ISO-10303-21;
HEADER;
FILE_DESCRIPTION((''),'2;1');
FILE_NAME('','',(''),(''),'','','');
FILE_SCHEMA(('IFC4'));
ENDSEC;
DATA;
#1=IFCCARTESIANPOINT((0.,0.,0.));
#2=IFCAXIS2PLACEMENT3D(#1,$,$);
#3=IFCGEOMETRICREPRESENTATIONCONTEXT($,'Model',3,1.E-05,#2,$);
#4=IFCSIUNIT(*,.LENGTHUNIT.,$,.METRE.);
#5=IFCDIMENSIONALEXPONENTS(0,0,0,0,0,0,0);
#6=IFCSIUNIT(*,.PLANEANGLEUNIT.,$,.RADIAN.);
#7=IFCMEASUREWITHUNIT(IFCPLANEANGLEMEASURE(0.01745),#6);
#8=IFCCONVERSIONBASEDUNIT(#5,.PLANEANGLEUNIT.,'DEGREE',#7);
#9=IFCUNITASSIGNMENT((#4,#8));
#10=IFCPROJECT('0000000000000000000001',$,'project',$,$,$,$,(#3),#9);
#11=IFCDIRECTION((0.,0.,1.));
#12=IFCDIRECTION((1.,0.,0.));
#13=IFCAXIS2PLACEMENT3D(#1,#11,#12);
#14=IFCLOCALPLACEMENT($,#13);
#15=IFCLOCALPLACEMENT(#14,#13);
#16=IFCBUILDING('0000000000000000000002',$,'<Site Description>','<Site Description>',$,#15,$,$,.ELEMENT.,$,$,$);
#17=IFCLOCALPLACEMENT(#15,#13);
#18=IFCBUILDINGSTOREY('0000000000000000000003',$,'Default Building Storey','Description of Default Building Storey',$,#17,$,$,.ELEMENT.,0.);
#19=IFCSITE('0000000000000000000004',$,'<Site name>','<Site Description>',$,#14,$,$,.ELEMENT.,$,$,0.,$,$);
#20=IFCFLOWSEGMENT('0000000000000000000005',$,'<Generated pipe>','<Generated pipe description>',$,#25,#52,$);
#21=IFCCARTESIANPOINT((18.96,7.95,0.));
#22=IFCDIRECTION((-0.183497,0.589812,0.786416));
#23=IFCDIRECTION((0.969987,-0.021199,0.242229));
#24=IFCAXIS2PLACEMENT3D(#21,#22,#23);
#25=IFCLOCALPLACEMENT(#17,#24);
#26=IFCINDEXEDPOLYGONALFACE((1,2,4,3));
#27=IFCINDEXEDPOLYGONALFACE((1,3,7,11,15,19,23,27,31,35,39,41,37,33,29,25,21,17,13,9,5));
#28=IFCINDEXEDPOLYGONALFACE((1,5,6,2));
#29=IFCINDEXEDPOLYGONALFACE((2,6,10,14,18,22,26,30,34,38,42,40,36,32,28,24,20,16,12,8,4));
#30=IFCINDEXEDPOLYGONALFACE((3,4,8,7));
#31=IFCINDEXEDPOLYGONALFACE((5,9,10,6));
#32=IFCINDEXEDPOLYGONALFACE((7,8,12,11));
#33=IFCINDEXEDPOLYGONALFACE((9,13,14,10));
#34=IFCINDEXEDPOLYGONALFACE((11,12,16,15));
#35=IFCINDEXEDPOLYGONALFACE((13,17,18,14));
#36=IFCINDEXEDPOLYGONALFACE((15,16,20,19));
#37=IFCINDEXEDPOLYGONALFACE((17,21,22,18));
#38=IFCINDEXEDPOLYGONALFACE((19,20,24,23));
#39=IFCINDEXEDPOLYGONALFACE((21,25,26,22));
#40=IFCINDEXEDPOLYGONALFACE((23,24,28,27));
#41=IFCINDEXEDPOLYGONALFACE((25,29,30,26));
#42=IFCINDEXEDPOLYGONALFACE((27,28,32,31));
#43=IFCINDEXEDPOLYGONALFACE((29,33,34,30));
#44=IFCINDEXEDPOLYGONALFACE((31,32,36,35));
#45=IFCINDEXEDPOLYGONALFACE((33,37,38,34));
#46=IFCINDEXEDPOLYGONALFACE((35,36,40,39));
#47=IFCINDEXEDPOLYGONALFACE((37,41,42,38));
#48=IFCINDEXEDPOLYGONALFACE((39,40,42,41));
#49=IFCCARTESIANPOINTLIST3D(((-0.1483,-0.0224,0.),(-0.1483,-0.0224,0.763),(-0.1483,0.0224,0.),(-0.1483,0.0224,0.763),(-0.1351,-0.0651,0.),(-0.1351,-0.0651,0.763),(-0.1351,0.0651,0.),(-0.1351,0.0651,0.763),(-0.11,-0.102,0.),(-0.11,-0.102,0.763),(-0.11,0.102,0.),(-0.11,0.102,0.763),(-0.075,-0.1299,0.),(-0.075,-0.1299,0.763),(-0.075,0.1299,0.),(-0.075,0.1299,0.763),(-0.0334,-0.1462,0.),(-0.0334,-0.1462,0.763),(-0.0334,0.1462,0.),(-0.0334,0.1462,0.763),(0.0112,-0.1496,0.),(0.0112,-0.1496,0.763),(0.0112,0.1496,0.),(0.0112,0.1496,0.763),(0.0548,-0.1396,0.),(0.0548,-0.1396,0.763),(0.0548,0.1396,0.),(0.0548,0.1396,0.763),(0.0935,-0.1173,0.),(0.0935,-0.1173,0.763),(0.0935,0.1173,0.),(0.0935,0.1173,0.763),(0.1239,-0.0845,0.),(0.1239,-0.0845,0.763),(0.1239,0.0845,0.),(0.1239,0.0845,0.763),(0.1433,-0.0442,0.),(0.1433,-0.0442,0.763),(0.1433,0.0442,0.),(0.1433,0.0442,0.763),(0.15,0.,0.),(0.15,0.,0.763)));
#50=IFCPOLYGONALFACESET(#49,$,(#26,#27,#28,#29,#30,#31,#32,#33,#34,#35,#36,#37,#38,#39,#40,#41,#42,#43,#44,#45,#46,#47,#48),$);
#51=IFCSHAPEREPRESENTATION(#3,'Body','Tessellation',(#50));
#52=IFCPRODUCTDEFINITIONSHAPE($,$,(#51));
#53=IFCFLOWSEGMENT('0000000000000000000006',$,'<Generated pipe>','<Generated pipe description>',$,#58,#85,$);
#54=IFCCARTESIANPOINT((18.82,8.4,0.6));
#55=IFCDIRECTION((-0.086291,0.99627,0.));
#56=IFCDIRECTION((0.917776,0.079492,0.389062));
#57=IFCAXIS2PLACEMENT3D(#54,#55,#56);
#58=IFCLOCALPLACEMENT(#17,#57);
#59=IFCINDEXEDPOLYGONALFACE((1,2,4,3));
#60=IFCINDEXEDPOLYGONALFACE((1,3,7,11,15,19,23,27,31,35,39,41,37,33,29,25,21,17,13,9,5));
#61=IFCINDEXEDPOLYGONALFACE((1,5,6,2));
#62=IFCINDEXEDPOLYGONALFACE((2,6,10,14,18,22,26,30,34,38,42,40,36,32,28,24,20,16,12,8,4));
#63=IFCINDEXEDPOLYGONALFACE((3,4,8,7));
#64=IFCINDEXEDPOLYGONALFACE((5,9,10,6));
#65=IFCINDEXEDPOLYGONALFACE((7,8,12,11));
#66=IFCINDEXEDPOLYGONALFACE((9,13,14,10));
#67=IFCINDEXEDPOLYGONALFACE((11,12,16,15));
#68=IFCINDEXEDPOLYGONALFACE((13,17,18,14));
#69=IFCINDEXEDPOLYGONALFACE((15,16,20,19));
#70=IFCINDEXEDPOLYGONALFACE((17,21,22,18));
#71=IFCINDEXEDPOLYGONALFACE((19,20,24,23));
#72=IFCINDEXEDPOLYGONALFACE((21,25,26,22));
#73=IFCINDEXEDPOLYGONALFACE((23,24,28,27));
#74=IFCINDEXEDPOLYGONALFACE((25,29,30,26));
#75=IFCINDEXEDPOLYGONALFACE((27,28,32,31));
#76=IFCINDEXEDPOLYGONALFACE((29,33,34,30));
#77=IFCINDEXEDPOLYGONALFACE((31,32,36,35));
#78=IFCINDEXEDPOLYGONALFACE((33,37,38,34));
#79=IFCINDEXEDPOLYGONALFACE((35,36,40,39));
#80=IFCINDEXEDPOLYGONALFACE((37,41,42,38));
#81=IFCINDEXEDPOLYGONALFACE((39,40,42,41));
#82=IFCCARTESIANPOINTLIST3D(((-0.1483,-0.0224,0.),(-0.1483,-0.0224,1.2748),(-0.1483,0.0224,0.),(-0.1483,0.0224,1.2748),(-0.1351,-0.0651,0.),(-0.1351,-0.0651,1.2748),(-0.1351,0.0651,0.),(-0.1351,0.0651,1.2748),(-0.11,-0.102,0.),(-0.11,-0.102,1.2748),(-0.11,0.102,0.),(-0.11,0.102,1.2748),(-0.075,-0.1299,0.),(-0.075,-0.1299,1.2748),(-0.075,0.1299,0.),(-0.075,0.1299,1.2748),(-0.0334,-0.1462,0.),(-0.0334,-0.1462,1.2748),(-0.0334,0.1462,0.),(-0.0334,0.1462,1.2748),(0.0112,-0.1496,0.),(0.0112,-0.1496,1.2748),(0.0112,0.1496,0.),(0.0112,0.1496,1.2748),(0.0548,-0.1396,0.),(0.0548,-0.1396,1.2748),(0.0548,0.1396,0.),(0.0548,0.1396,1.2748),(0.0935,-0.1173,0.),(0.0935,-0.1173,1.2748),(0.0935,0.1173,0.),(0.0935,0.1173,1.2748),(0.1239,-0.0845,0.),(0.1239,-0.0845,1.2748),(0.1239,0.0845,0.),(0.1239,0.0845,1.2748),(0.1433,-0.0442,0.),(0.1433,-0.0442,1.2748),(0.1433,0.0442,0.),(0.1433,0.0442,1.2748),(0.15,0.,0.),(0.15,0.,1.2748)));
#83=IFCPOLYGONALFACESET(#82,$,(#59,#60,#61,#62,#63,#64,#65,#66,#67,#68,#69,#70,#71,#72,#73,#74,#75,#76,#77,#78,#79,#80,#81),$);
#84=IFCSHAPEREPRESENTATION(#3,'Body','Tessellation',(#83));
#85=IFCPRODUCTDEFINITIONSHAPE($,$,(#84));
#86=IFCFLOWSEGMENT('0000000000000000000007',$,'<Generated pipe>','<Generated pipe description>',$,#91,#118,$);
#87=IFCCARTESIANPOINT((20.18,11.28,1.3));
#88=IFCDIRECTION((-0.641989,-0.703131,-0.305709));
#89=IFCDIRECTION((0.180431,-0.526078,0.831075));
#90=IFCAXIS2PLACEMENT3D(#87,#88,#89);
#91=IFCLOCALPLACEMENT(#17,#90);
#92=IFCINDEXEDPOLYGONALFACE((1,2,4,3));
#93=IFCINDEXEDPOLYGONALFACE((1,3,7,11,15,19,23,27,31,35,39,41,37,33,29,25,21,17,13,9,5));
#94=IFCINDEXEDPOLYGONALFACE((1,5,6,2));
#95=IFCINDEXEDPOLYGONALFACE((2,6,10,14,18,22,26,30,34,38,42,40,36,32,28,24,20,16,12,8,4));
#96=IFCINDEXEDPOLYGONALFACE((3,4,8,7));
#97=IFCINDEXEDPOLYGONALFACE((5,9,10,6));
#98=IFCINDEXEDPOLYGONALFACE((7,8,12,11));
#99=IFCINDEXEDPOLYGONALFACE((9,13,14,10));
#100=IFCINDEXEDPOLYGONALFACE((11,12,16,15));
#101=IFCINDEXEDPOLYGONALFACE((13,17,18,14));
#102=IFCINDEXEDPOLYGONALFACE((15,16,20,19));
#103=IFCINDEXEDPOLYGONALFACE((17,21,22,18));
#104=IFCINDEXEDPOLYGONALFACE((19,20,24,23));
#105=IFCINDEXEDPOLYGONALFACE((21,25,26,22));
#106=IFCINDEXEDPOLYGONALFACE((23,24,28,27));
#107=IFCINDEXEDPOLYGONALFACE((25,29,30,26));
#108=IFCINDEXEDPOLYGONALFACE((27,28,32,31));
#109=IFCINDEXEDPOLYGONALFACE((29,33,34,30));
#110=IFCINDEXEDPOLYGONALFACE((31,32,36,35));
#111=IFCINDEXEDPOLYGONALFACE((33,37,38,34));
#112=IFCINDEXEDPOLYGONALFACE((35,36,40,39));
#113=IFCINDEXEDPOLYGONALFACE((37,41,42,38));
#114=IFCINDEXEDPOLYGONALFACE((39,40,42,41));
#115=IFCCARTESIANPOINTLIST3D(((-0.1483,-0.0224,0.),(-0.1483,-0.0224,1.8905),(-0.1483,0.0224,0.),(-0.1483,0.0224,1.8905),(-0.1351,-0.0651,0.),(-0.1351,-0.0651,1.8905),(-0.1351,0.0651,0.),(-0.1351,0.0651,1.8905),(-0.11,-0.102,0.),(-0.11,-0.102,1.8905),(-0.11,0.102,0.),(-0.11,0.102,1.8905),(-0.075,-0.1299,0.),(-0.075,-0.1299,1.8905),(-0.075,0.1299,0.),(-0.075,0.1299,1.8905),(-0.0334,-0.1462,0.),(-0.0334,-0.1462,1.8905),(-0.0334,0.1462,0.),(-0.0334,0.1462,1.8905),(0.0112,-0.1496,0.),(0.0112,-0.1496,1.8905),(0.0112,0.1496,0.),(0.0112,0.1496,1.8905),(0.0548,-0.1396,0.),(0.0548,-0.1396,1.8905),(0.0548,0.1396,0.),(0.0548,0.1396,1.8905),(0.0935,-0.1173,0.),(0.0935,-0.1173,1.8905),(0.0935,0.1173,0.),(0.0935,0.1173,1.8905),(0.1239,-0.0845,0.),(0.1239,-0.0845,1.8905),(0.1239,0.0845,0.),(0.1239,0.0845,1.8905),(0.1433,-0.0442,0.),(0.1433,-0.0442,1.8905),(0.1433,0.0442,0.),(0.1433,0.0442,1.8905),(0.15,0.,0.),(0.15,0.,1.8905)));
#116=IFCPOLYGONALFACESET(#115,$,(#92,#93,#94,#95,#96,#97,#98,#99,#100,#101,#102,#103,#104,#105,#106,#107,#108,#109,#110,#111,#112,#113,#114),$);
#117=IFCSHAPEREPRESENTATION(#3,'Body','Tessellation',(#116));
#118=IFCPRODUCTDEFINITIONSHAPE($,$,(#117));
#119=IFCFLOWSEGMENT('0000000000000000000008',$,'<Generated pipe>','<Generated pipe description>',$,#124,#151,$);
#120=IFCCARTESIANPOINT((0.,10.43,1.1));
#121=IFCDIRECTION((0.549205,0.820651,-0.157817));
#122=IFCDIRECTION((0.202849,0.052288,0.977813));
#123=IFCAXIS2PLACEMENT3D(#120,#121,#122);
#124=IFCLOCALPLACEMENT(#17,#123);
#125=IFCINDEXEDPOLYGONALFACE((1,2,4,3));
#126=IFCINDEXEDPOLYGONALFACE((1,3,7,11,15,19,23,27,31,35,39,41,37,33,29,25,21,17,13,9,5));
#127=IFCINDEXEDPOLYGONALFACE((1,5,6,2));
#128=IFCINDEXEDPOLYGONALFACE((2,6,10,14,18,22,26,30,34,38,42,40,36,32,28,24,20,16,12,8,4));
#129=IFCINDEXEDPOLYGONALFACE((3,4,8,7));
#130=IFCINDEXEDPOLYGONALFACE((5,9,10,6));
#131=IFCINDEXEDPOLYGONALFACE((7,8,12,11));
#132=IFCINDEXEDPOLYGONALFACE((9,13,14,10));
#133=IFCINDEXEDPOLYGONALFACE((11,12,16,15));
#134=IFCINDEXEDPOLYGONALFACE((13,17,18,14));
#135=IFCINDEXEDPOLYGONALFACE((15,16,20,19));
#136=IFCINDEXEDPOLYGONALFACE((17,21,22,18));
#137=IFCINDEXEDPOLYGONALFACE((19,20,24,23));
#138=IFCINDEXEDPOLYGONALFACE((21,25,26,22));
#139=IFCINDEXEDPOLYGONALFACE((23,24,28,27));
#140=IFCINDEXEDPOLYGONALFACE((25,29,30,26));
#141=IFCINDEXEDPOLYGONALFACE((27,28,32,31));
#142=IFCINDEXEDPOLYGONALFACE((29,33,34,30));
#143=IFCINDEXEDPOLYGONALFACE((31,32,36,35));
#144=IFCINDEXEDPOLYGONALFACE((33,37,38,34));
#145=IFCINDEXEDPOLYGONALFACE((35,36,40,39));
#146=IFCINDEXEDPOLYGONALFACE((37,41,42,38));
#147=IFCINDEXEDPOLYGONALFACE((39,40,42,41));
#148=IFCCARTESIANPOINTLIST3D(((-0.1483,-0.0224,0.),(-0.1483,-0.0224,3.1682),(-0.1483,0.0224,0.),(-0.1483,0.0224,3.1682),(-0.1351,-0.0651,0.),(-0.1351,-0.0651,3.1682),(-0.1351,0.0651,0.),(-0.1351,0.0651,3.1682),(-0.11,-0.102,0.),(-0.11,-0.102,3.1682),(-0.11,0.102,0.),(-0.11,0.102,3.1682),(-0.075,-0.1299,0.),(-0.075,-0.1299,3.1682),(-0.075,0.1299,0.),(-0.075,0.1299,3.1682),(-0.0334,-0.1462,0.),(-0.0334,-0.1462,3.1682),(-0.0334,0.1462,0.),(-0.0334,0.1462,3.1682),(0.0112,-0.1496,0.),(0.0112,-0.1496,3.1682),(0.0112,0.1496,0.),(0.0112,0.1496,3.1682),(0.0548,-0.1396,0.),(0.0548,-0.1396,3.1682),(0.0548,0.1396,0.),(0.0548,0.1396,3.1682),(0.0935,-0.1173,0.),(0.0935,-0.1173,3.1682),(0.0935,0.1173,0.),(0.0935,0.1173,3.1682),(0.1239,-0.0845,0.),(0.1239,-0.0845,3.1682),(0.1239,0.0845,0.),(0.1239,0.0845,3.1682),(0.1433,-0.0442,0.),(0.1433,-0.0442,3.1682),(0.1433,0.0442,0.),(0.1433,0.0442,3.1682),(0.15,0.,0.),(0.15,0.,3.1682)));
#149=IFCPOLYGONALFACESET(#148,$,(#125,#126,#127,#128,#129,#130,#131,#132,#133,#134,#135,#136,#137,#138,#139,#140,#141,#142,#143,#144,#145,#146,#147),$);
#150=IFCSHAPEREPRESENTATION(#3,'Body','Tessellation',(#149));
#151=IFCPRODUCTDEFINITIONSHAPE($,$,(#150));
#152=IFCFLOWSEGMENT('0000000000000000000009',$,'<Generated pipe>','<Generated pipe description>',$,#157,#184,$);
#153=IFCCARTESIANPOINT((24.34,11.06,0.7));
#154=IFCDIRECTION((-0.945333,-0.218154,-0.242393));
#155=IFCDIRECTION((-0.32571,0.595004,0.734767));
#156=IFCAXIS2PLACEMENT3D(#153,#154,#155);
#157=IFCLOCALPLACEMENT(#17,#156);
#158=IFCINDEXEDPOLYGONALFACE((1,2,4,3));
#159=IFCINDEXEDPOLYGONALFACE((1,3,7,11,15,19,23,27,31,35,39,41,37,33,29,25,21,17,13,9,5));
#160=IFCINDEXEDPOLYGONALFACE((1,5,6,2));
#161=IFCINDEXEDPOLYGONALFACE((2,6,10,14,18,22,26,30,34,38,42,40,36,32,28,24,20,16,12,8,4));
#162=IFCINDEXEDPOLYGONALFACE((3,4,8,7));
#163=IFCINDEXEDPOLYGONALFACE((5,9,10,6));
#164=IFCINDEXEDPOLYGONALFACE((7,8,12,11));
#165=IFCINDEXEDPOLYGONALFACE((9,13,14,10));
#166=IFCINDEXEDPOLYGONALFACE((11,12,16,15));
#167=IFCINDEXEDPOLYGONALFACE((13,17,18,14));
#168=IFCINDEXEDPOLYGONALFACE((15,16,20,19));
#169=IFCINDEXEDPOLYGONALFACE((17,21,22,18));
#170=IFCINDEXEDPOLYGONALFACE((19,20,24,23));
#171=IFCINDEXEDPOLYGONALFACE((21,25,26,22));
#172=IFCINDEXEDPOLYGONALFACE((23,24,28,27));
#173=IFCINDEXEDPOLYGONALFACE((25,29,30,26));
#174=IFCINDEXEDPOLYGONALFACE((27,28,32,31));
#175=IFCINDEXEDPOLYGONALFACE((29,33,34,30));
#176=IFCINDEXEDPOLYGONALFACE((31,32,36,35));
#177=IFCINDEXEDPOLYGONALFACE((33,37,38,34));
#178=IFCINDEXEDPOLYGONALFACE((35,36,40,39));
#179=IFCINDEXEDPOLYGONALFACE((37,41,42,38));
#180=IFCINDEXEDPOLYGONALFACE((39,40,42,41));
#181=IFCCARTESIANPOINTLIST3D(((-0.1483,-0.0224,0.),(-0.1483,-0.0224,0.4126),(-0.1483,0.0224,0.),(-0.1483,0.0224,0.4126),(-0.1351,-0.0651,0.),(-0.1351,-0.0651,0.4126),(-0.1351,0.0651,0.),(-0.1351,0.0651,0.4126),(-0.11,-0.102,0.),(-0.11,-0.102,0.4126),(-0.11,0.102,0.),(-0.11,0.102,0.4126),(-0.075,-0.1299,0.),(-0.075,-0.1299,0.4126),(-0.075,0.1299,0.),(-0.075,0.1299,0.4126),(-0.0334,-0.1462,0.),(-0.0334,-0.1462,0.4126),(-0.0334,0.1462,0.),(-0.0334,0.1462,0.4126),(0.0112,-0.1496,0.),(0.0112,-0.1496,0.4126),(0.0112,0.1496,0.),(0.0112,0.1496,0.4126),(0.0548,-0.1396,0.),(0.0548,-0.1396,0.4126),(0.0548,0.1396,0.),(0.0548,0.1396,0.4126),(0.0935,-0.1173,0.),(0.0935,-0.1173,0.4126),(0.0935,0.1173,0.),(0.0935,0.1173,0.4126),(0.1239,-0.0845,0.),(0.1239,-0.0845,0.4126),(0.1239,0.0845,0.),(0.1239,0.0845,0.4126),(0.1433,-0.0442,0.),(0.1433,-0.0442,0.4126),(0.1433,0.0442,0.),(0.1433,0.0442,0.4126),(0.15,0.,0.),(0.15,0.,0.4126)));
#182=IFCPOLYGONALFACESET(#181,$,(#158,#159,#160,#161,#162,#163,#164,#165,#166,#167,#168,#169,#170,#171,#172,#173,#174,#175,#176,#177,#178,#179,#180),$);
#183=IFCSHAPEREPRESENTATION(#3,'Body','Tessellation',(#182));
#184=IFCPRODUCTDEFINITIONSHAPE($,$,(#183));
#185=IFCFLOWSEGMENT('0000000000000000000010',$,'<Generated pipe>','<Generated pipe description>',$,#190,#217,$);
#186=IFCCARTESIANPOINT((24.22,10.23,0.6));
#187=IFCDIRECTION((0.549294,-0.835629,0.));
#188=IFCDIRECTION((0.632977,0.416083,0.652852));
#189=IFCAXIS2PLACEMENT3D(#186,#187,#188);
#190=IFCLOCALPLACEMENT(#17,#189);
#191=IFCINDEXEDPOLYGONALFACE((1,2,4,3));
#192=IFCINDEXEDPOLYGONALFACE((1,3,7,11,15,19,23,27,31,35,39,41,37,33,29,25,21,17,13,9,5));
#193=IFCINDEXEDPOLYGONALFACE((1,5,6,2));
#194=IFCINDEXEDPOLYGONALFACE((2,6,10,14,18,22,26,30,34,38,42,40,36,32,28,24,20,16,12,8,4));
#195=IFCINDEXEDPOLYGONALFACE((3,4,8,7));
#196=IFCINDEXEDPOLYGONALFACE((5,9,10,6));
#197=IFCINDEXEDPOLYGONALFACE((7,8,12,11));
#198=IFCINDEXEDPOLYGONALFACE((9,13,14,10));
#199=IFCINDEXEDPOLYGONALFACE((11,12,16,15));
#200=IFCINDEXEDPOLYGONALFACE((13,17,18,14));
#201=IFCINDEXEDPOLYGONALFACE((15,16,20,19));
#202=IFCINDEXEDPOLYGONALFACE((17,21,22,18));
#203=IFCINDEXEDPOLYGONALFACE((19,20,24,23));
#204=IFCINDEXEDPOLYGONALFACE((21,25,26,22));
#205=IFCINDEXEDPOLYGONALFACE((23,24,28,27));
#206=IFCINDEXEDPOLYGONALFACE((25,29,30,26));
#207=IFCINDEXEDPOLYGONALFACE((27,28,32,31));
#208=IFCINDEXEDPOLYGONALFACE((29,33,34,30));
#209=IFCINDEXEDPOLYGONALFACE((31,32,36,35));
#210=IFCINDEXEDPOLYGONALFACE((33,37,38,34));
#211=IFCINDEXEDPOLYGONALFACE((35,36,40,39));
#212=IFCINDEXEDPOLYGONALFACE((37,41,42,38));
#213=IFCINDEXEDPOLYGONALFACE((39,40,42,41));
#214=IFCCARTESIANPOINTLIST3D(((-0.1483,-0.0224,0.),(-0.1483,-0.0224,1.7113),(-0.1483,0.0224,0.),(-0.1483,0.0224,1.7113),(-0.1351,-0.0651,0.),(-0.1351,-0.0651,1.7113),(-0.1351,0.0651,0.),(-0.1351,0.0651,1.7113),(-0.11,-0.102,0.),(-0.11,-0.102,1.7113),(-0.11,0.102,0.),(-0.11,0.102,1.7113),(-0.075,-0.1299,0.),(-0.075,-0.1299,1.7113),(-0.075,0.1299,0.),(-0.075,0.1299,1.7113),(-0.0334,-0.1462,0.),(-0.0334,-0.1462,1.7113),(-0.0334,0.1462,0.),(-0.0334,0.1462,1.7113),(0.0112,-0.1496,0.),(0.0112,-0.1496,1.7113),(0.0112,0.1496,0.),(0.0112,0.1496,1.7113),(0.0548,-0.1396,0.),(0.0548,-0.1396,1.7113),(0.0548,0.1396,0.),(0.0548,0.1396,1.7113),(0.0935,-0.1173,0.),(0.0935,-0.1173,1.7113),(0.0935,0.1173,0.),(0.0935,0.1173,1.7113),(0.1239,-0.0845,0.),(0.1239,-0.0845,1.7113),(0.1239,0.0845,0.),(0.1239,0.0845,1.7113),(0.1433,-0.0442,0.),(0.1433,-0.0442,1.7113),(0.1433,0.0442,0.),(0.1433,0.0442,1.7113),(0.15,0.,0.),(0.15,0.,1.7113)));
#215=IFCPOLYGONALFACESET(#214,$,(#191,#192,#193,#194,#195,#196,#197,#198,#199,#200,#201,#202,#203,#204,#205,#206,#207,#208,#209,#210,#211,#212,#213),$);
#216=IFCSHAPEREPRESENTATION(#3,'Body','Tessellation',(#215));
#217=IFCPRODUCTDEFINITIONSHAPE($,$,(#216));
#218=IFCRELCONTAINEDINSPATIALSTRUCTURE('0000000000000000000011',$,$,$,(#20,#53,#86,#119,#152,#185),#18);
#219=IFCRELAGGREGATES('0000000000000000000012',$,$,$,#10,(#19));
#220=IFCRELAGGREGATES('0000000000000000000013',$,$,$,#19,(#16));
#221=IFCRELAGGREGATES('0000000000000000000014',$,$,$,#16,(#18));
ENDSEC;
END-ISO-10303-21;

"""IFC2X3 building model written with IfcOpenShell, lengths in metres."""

from ifc_helpers import new_model, entity, si_unit, converted_unit, frame, origin, origin_with_axes, origin_2d_with_axis, place, context, project, spatial, circle, extrude, element, save


model = new_model("IFC2X3")

# Units and contexts
model_context = context("Model", 3, precision=1e-05, world=origin())
ifc_project = project(units=[si_unit("LENGTHUNIT", "METRE"), converted_unit("PLANEANGLEUNIT", "DEGREE", entity("IfcPlaneAngleMeasure", 0.01745), si_unit("PLANEANGLEUNIT", "RADIAN"), dimensions=[0, 0, 0, 0, 0, 0, 0])], contexts=[model_context])

# Site, building, storey
site_placement = place(None, origin_with_axes())
site = spatial("IfcSite", under=ifc_project, at=site_placement, Name="<Site name>", Description="<Site Description>", CompositionType="ELEMENT", RefElevation=0.0)
building_placement = place(site_placement, origin_with_axes())
building = spatial("IfcBuilding", under=site, at=building_placement, Name="<Site Description>", Description="<Site Description>", CompositionType="ELEMENT")
storey_placement = place(building_placement, origin_with_axes())
storey = spatial("IfcBuildingStorey", under=building, at=storey_placement, Name="Default Building Storey", Description="Description of Default Building Storey", CompositionType="ELEMENT", Elevation=0.0)

# Flow segments
flow_segment_1_placement = place(storey_placement, frame((18.96, 7.95, 0.0), z_axis=(-0.183497, 0.589812, 0.786416), x_axis=(0.969987, -0.021199, 0.242229)))
element("IfcFlowSegment", 1, at=flow_segment_1_placement, inside=storey, Name="<Generated pipe>", Description="<Generated pipe description>", context=model_context, shape_type="SweptSolid", body=[
    extrude(circle(Radius=0.15, at=origin_2d_with_axis()), origin_with_axes(), (0.0, 0.0, 1.0), 0.763),
])
flow_segment_2_placement = place(storey_placement, frame((18.82, 8.4, 0.6), z_axis=(-0.086291, 0.99627, 0.0), x_axis=(0.917776, 0.079492, 0.389062)))
element("IfcFlowSegment", 2, at=flow_segment_2_placement, inside=storey, Name="<Generated pipe>", Description="<Generated pipe description>", context=model_context, shape_type="SweptSolid", body=[
    extrude(circle(Radius=0.15, at=origin_2d_with_axis()), origin_with_axes(), (0.0, 0.0, 1.0), 1.2748),
])
flow_segment_3_placement = place(storey_placement, frame((20.18, 11.28, 1.3), z_axis=(-0.641989, -0.703131, -0.305709), x_axis=(0.180431, -0.526078, 0.831075)))
element("IfcFlowSegment", 3, at=flow_segment_3_placement, inside=storey, Name="<Generated pipe>", Description="<Generated pipe description>", context=model_context, shape_type="SweptSolid", body=[
    extrude(circle(Radius=0.15, at=origin_2d_with_axis()), origin_with_axes(), (0.0, 0.0, 1.0), 1.8905),
])
flow_segment_4_placement = place(storey_placement, frame((0.0, 10.43, 1.1), z_axis=(0.549205, 0.820651, -0.157817), x_axis=(0.202849, 0.052288, 0.977813)))
element("IfcFlowSegment", 4, at=flow_segment_4_placement, inside=storey, Name="<Generated pipe>", Description="<Generated pipe description>", context=model_context, shape_type="SweptSolid", body=[
    extrude(circle(Radius=0.15, at=origin_2d_with_axis()), origin_with_axes(), (0.0, 0.0, 1.0), 3.1682),
])
flow_segment_5_placement = place(storey_placement, frame((24.34, 11.06, 0.7), z_axis=(-0.945333, -0.218154, -0.242393), x_axis=(-0.32571, 0.595004, 0.734767)))
element("IfcFlowSegment", 5, at=flow_segment_5_placement, inside=storey, Name="<Generated pipe>", Description="<Generated pipe description>", context=model_context, shape_type="SweptSolid", body=[
    extrude(circle(Radius=0.15, at=origin_2d_with_axis()), origin_with_axes(), (0.0, 0.0, 1.0), 0.4126),
])
flow_segment_6_placement = place(storey_placement, frame((24.22, 10.23, 0.6), z_axis=(0.549294, -0.835629, 0.0), x_axis=(0.632977, 0.416083, 0.652852)))
element("IfcFlowSegment", 6, at=flow_segment_6_placement, inside=storey, Name="<Generated pipe>", Description="<Generated pipe description>", context=model_context, shape_type="SweptSolid", body=[
    extrude(circle(Radius=0.15, at=origin_2d_with_axis()), origin_with_axes(), (0.0, 0.0, 1.0), 1.7113),
])

save(model, "model.ifc")
